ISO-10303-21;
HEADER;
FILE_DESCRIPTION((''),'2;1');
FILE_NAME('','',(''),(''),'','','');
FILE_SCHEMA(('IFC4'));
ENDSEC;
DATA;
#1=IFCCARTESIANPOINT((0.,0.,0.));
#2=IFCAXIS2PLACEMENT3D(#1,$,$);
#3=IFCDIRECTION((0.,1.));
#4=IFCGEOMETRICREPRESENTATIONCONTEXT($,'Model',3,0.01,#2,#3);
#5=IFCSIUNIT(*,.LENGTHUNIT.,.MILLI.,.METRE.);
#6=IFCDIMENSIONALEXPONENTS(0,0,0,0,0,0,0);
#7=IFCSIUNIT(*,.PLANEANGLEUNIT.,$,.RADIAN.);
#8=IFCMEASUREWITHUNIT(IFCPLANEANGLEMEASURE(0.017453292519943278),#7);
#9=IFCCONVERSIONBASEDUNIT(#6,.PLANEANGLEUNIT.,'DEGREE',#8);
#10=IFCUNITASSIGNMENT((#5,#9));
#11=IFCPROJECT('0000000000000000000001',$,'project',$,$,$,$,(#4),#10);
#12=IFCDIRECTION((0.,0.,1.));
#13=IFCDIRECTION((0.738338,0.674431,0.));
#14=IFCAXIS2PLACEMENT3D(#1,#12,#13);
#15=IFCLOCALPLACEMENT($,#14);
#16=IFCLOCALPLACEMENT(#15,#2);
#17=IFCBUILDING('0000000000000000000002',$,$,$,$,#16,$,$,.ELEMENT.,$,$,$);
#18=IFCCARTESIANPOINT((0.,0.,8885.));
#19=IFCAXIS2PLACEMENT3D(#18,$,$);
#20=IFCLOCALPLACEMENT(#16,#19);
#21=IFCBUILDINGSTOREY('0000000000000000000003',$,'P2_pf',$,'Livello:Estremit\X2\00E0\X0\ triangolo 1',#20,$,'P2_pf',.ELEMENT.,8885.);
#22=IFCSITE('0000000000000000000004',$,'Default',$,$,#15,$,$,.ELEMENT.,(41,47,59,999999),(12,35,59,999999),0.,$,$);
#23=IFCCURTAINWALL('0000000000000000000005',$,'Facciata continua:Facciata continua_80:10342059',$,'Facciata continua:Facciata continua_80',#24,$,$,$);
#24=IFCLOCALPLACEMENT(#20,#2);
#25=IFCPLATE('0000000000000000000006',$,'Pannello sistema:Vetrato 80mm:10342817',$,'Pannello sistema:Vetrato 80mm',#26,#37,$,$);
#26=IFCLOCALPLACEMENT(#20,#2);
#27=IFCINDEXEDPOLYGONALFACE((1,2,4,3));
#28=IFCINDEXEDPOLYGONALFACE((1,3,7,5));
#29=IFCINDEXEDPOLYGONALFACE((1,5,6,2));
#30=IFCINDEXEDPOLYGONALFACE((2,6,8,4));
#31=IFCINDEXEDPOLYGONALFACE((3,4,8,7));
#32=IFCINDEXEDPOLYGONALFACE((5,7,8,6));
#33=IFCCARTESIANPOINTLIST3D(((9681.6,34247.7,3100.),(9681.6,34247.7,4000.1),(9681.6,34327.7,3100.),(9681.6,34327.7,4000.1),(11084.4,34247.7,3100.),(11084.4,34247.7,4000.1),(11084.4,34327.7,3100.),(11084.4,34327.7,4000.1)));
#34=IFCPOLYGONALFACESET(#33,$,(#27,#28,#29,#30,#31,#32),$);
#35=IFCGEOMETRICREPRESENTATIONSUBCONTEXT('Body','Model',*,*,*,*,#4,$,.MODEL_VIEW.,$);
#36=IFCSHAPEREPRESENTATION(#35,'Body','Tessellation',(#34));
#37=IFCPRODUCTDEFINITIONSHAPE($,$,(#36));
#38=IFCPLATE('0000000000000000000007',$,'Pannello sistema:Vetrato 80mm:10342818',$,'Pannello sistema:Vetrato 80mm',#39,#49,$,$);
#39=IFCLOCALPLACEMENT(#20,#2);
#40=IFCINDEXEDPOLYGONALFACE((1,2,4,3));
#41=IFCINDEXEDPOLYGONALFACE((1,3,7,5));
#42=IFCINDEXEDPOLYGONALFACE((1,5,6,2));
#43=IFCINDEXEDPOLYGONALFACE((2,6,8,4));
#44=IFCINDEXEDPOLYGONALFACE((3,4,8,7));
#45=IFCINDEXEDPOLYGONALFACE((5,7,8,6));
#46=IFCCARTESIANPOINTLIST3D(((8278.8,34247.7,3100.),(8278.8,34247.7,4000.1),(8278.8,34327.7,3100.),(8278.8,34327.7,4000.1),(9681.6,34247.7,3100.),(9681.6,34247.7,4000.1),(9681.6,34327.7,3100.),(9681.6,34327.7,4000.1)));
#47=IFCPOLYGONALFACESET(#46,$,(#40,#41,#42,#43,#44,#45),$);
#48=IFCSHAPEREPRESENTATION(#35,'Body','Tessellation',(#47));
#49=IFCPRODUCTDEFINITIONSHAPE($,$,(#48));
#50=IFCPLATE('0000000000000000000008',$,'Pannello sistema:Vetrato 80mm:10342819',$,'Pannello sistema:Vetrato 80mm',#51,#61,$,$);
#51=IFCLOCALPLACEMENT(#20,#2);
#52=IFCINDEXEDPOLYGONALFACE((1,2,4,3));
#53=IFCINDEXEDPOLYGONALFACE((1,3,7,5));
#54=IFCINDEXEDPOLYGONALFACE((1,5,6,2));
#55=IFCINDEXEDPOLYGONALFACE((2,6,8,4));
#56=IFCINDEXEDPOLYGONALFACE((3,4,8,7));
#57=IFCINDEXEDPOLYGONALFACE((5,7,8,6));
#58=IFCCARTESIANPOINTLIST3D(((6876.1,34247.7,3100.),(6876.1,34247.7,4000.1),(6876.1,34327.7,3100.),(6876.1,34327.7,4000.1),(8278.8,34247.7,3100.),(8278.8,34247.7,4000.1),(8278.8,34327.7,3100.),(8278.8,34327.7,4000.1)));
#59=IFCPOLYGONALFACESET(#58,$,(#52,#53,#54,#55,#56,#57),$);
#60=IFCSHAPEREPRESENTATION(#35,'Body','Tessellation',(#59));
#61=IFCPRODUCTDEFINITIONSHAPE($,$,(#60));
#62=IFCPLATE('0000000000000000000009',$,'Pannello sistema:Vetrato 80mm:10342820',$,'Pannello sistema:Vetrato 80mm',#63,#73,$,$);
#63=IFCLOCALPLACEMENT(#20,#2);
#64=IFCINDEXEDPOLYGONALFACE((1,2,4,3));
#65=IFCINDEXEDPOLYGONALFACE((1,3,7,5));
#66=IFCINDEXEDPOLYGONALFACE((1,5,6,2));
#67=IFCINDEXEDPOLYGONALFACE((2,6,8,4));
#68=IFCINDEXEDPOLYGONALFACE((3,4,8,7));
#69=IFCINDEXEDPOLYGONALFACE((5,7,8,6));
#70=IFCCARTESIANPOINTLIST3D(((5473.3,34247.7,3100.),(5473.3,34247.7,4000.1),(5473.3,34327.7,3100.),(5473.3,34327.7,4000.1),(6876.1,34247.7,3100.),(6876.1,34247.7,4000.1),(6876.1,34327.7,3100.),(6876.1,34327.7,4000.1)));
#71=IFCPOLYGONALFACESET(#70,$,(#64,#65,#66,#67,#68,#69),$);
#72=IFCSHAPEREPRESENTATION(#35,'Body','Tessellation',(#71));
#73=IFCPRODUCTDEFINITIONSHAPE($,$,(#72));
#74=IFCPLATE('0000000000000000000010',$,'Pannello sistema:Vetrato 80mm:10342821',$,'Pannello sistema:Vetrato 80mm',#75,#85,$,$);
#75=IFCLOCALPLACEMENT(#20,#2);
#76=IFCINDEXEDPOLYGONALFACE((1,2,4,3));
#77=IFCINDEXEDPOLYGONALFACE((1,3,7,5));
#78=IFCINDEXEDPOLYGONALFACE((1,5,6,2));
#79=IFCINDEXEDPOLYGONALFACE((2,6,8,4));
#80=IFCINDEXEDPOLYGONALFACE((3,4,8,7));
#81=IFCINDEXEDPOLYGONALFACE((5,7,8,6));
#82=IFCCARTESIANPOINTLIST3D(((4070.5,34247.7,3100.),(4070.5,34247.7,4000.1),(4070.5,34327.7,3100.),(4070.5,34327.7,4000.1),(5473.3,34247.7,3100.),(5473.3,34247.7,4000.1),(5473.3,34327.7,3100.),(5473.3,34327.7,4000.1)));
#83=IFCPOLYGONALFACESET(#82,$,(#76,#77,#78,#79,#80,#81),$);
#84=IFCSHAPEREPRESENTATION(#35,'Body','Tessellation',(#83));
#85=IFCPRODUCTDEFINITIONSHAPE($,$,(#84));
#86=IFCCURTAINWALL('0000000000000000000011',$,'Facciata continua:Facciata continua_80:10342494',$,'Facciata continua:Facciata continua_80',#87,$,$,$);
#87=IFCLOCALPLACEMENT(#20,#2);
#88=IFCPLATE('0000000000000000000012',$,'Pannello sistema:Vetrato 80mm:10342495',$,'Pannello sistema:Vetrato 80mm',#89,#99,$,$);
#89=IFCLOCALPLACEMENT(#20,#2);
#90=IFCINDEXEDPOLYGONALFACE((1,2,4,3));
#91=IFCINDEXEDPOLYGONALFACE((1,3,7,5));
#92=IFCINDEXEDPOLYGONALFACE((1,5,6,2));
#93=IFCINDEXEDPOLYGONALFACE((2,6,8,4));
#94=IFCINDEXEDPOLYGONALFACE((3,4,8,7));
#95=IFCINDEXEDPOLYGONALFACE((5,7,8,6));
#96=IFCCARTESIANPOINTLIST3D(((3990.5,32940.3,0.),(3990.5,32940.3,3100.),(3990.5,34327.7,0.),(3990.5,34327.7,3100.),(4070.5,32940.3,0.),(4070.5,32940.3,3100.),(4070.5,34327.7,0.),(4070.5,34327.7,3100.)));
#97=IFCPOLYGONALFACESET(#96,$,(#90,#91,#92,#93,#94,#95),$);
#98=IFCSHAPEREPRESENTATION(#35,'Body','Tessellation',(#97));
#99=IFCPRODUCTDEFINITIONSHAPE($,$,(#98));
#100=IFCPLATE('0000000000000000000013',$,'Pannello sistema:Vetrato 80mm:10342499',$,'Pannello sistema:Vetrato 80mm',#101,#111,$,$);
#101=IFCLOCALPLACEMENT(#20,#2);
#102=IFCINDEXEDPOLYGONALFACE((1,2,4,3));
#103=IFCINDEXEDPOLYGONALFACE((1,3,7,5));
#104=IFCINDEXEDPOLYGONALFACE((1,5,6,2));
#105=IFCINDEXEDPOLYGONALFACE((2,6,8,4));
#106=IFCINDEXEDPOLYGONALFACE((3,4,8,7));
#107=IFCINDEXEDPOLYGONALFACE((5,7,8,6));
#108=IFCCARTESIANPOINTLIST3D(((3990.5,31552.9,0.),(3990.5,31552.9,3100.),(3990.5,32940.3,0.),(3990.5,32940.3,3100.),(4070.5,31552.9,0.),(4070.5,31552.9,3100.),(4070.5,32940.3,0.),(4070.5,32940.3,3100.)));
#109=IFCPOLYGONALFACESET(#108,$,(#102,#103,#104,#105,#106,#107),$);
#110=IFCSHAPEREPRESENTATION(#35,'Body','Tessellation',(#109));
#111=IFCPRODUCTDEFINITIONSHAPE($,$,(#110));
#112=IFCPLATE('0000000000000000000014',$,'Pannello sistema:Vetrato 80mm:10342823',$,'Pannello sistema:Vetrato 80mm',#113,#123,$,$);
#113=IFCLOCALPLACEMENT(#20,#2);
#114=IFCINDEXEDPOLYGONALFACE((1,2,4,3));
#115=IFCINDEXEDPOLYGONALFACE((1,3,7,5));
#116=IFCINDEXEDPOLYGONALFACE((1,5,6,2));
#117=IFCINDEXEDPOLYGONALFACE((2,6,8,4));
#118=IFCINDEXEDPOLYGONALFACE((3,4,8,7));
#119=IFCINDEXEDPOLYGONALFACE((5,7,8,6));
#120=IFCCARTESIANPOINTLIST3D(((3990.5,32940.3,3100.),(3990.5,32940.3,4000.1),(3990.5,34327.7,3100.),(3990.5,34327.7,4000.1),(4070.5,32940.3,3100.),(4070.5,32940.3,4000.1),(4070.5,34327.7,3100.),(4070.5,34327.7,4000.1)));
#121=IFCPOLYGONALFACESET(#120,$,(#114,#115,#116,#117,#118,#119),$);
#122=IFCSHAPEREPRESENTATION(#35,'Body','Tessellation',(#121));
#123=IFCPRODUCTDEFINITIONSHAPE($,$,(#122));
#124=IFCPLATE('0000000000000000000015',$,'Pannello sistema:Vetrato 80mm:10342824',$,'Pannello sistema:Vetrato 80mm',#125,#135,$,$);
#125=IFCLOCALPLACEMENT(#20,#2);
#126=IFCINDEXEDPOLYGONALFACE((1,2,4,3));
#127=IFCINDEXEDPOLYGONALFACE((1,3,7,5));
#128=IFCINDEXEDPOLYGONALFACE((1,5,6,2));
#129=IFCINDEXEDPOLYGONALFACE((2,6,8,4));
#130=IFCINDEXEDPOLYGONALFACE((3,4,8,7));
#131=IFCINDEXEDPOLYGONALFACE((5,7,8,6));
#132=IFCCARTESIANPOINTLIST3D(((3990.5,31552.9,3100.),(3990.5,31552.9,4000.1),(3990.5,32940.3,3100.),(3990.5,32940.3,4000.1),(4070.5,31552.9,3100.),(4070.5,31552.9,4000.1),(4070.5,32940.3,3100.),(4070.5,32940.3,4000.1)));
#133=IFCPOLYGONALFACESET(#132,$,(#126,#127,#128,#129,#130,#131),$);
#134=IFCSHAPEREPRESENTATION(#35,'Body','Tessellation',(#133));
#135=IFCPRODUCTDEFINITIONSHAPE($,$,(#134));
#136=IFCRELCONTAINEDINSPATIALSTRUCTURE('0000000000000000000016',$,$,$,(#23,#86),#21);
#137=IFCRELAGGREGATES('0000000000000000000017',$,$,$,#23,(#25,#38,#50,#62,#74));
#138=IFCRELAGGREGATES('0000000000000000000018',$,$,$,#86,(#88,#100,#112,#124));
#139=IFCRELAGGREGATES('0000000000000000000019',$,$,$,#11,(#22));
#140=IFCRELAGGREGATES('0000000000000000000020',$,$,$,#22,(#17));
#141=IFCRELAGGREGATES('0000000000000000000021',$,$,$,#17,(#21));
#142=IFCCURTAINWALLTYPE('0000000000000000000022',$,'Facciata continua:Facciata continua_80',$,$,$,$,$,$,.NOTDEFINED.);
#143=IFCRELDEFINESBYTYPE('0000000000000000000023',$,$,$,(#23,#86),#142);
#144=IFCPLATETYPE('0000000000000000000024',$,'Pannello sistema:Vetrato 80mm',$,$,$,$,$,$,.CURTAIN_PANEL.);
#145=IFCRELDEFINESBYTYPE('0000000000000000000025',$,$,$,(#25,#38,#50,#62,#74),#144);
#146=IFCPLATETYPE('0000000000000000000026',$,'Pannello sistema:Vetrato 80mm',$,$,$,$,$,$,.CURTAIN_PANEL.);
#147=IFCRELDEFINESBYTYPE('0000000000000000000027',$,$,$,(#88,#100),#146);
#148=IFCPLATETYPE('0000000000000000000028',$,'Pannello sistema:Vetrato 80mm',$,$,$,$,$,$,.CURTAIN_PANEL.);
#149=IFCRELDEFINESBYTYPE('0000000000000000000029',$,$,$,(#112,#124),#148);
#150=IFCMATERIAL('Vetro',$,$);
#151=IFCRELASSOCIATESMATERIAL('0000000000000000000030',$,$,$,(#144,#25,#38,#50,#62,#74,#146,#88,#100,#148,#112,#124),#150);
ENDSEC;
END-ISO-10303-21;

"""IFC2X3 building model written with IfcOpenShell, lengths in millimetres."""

from ifc_helpers import new_model, entity, si_unit, converted_unit, direction, frame, frame_2d, origin, origin_2d_with_axis, place, context, subcontext, project, spatial, rectangle, extrude, source, transform, mapped, material, type_object, type_shapes, element, aggregate, save


model = new_model("IFC2X3")

# Units and contexts
model_context = context("Model", 3, precision=0.01, world=origin(), true_north=direction((0.0, 1.0)))
body_context = subcontext(model_context, "Body", "Model", "MODEL_VIEW")
ifc_project = project(units=[si_unit("LENGTHUNIT", "METRE", prefix="MILLI"), converted_unit("PLANEANGLEUNIT", "DEGREE", entity("IfcPlaneAngleMeasure", 0.017453292519943278), si_unit("PLANEANGLEUNIT", "RADIAN"), dimensions=[0, 0, 0, 0, 0, 0, 0])], contexts=[model_context])

# Site, building, storey
site_placement = place(None, frame((0.0, 0.0, 0.0), z_axis=(0.0, 0.0, 1.0), x_axis=(0.738338, 0.674431, 0.0)))
site = spatial("IfcSite", under=ifc_project, at=site_placement, Name="Default", CompositionType="ELEMENT", RefLatitude=(41, 47, 59, 999999), RefLongitude=(12, 35, 59, 999999), RefElevation=0.0)
building_placement = place(site_placement, origin())
building = spatial("IfcBuilding", under=site, at=building_placement, CompositionType="ELEMENT")
storey_placement = place(building_placement, frame((0.0, 0.0, 8885.0)))
storey = spatial("IfcBuildingStorey", under=building, at=storey_placement, Name="P2_pf", ObjectType="Livello:Estremità triangolo 1", LongName="P2_pf", CompositionType="ELEMENT", Elevation=8885.0)

# Curtain walls, plates
curtain_wall_type = type_object("IfcCurtainWallType", Name="Facciata continua:Facciata continua_80", PredefinedType="NOTDEFINED")
curtain_wall_1_placement = place(storey_placement, frame((0.0, 0.0, -8885.0)))
curtain_wall_1 = element("IfcCurtainWall", 1, at=curtain_wall_1_placement, inside=storey, type_object=curtain_wall_type, Name="Facciata continua:Facciata continua_80:10342059", ObjectType="Facciata continua:Facciata continua_80")
ifc_material_1 = material(Name="Vetro")
plate_type_1 = type_object("IfcPlateType", Name="Pannello sistema:Vetrato 80mm", PredefinedType="CURTAIN_PANEL", material=ifc_material_1)
shared_shape_1 = source(origin(), body_context, "Body", "SweptSolid", [
    extrude(rectangle(XDim=80.0, YDim=1402.8, at=origin_2d_with_axis()), frame((0.0, -40.0, 0.0), z_axis=(0.0, 0.0, 1.0), x_axis=(0.0, 1.0, 0.0)), (0.0, 0.0, 1.0), 900.1),
])
type_shapes(plate_type_1, [shared_shape_1])
plate_1_placement = place(curtain_wall_1_placement, frame((10383.0, 34247.7, 11985.0), z_axis=(0.0, 0.0, 1.0), x_axis=(-1.0, 0.0, 0.0)))
plate_1 = element("IfcPlate", 2, at=plate_1_placement, type_object=plate_type_1, material=ifc_material_1, Name="Pannello sistema:Vetrato 80mm:10342817", ObjectType="Pannello sistema:Vetrato 80mm", context=body_context, shape_type="MappedRepresentation", body=[
    mapped(shared_shape_1, transform((0.0, 0.0, 0.0), scale=1.0)),
])
plate_2_placement = place(curtain_wall_1_placement, frame((8980.2, 34247.7, 11985.0), z_axis=(0.0, 0.0, 1.0), x_axis=(-1.0, 0.0, 0.0)))
plate_2 = element("IfcPlate", 3, at=plate_2_placement, type_object=plate_type_1, material=ifc_material_1, Name="Pannello sistema:Vetrato 80mm:10342818", ObjectType="Pannello sistema:Vetrato 80mm", context=body_context, shape_type="MappedRepresentation", body=[
    mapped(shared_shape_1, transform((0.0, 0.0, 0.0), scale=1.0)),
])
plate_3_placement = place(curtain_wall_1_placement, frame((7577.4, 34247.7, 11985.0), z_axis=(0.0, 0.0, 1.0), x_axis=(-1.0, 0.0, 0.0)))
plate_3 = element("IfcPlate", 4, at=plate_3_placement, type_object=plate_type_1, material=ifc_material_1, Name="Pannello sistema:Vetrato 80mm:10342819", ObjectType="Pannello sistema:Vetrato 80mm", context=body_context, shape_type="MappedRepresentation", body=[
    mapped(shared_shape_1, transform((0.0, 0.0, 0.0), scale=1.0)),
])
plate_4_placement = place(curtain_wall_1_placement, frame((6174.7, 34247.7, 11985.0), z_axis=(0.0, 0.0, 1.0), x_axis=(-1.0, 0.0, 0.0)))
plate_4 = element("IfcPlate", 5, at=plate_4_placement, type_object=plate_type_1, material=ifc_material_1, Name="Pannello sistema:Vetrato 80mm:10342820", ObjectType="Pannello sistema:Vetrato 80mm", context=body_context, shape_type="MappedRepresentation", body=[
    mapped(shared_shape_1, transform((0.0, 0.0, 0.0), scale=1.0)),
])
plate_5_placement = place(curtain_wall_1_placement, frame((4771.9, 34247.7, 11985.0), z_axis=(0.0, 0.0, 1.0), x_axis=(-1.0, 0.0, 0.0)))
plate_5 = element("IfcPlate", 6, at=plate_5_placement, type_object=plate_type_1, material=ifc_material_1, Name="Pannello sistema:Vetrato 80mm:10342821", ObjectType="Pannello sistema:Vetrato 80mm", context=body_context, shape_type="MappedRepresentation", body=[
    mapped(shared_shape_1, transform((0.0, 0.0, 0.0), scale=1.0)),
])
aggregate(curtain_wall_1, [plate_1, plate_2, plate_3, plate_4, plate_5])
curtain_wall_2_placement = place(storey_placement, frame((0.0, 0.0, -8885.0)))
curtain_wall_2 = element("IfcCurtainWall", 7, at=curtain_wall_2_placement, inside=storey, type_object=curtain_wall_type, Name="Facciata continua:Facciata continua_80:10342494", ObjectType="Facciata continua:Facciata continua_80")
plate_type_2 = type_object("IfcPlateType", Name="Pannello sistema:Vetrato 80mm", PredefinedType="CURTAIN_PANEL", material=ifc_material_1)
shared_shape_2 = source(origin(), body_context, "Body", "SweptSolid", [
    extrude(rectangle(XDim=80.0, YDim=1387.4, at=frame_2d((0.0, 0.0), x_axis=(1.0, 0.0))), frame((0.0, -40.0, 0.0), z_axis=(0.0, 0.0, 1.0), x_axis=(0.0, 1.0, 0.0)), (0.0, 0.0, 1.0), 3100.0),
])
type_shapes(plate_type_2, [shared_shape_2])
plate_6_placement = place(curtain_wall_2_placement, frame((4070.5, 33634.0, 8885.0), z_axis=(0.0, 0.0, 1.0), x_axis=(0.0, -1.0, 0.0)))
plate_6 = element("IfcPlate", 8, at=plate_6_placement, type_object=plate_type_2, material=ifc_material_1, Name="Pannello sistema:Vetrato 80mm:10342495", ObjectType="Pannello sistema:Vetrato 80mm", context=body_context, shape_type="MappedRepresentation", body=[
    mapped(shared_shape_2, transform((0.0, 0.0, 0.0), scale=1.0)),
])
plate_7_placement = place(curtain_wall_2_placement, frame((4070.5, 32246.6, 8885.0), z_axis=(0.0, 0.0, 1.0), x_axis=(0.0, -1.0, 0.0)))
plate_7 = element("IfcPlate", 9, at=plate_7_placement, type_object=plate_type_2, material=ifc_material_1, Name="Pannello sistema:Vetrato 80mm:10342499", ObjectType="Pannello sistema:Vetrato 80mm", context=body_context, shape_type="MappedRepresentation", body=[
    mapped(shared_shape_2, transform((0.0, 0.0, 0.0), scale=1.0)),
])
plate_type_3 = type_object("IfcPlateType", Name="Pannello sistema:Vetrato 80mm", PredefinedType="CURTAIN_PANEL", material=ifc_material_1)
shared_shape_3 = source(origin(), body_context, "Body", "SweptSolid", [
    extrude(rectangle(XDim=80.0, YDim=1387.4, at=frame_2d((0.0, 0.0), x_axis=(1.0, 0.0))), frame((0.0, -40.0, 0.0), z_axis=(0.0, 0.0, 1.0), x_axis=(0.0, 1.0, 0.0)), (0.0, 0.0, 1.0), 900.1),
])
type_shapes(plate_type_3, [shared_shape_3])
plate_8_placement = place(curtain_wall_2_placement, frame((4070.5, 33634.0, 11985.0), z_axis=(0.0, 0.0, 1.0), x_axis=(0.0, -1.0, 0.0)))
plate_8 = element("IfcPlate", 10, at=plate_8_placement, type_object=plate_type_3, material=ifc_material_1, Name="Pannello sistema:Vetrato 80mm:10342823", ObjectType="Pannello sistema:Vetrato 80mm", context=body_context, shape_type="MappedRepresentation", body=[
    mapped(shared_shape_3, transform((0.0, 0.0, 0.0), scale=1.0)),
])
plate_9_placement = place(curtain_wall_2_placement, frame((4070.5, 32246.6, 11985.0), z_axis=(0.0, 0.0, 1.0), x_axis=(0.0, -1.0, 0.0)))
plate_9 = element("IfcPlate", 11, at=plate_9_placement, type_object=plate_type_3, material=ifc_material_1, Name="Pannello sistema:Vetrato 80mm:10342824", ObjectType="Pannello sistema:Vetrato 80mm", context=body_context, shape_type="MappedRepresentation", body=[
    mapped(shared_shape_3, transform((0.0, 0.0, 0.0), scale=1.0)),
])
aggregate(curtain_wall_2, [plate_6, plate_7, plate_8, plate_9])

save(model, "model.ifc")
